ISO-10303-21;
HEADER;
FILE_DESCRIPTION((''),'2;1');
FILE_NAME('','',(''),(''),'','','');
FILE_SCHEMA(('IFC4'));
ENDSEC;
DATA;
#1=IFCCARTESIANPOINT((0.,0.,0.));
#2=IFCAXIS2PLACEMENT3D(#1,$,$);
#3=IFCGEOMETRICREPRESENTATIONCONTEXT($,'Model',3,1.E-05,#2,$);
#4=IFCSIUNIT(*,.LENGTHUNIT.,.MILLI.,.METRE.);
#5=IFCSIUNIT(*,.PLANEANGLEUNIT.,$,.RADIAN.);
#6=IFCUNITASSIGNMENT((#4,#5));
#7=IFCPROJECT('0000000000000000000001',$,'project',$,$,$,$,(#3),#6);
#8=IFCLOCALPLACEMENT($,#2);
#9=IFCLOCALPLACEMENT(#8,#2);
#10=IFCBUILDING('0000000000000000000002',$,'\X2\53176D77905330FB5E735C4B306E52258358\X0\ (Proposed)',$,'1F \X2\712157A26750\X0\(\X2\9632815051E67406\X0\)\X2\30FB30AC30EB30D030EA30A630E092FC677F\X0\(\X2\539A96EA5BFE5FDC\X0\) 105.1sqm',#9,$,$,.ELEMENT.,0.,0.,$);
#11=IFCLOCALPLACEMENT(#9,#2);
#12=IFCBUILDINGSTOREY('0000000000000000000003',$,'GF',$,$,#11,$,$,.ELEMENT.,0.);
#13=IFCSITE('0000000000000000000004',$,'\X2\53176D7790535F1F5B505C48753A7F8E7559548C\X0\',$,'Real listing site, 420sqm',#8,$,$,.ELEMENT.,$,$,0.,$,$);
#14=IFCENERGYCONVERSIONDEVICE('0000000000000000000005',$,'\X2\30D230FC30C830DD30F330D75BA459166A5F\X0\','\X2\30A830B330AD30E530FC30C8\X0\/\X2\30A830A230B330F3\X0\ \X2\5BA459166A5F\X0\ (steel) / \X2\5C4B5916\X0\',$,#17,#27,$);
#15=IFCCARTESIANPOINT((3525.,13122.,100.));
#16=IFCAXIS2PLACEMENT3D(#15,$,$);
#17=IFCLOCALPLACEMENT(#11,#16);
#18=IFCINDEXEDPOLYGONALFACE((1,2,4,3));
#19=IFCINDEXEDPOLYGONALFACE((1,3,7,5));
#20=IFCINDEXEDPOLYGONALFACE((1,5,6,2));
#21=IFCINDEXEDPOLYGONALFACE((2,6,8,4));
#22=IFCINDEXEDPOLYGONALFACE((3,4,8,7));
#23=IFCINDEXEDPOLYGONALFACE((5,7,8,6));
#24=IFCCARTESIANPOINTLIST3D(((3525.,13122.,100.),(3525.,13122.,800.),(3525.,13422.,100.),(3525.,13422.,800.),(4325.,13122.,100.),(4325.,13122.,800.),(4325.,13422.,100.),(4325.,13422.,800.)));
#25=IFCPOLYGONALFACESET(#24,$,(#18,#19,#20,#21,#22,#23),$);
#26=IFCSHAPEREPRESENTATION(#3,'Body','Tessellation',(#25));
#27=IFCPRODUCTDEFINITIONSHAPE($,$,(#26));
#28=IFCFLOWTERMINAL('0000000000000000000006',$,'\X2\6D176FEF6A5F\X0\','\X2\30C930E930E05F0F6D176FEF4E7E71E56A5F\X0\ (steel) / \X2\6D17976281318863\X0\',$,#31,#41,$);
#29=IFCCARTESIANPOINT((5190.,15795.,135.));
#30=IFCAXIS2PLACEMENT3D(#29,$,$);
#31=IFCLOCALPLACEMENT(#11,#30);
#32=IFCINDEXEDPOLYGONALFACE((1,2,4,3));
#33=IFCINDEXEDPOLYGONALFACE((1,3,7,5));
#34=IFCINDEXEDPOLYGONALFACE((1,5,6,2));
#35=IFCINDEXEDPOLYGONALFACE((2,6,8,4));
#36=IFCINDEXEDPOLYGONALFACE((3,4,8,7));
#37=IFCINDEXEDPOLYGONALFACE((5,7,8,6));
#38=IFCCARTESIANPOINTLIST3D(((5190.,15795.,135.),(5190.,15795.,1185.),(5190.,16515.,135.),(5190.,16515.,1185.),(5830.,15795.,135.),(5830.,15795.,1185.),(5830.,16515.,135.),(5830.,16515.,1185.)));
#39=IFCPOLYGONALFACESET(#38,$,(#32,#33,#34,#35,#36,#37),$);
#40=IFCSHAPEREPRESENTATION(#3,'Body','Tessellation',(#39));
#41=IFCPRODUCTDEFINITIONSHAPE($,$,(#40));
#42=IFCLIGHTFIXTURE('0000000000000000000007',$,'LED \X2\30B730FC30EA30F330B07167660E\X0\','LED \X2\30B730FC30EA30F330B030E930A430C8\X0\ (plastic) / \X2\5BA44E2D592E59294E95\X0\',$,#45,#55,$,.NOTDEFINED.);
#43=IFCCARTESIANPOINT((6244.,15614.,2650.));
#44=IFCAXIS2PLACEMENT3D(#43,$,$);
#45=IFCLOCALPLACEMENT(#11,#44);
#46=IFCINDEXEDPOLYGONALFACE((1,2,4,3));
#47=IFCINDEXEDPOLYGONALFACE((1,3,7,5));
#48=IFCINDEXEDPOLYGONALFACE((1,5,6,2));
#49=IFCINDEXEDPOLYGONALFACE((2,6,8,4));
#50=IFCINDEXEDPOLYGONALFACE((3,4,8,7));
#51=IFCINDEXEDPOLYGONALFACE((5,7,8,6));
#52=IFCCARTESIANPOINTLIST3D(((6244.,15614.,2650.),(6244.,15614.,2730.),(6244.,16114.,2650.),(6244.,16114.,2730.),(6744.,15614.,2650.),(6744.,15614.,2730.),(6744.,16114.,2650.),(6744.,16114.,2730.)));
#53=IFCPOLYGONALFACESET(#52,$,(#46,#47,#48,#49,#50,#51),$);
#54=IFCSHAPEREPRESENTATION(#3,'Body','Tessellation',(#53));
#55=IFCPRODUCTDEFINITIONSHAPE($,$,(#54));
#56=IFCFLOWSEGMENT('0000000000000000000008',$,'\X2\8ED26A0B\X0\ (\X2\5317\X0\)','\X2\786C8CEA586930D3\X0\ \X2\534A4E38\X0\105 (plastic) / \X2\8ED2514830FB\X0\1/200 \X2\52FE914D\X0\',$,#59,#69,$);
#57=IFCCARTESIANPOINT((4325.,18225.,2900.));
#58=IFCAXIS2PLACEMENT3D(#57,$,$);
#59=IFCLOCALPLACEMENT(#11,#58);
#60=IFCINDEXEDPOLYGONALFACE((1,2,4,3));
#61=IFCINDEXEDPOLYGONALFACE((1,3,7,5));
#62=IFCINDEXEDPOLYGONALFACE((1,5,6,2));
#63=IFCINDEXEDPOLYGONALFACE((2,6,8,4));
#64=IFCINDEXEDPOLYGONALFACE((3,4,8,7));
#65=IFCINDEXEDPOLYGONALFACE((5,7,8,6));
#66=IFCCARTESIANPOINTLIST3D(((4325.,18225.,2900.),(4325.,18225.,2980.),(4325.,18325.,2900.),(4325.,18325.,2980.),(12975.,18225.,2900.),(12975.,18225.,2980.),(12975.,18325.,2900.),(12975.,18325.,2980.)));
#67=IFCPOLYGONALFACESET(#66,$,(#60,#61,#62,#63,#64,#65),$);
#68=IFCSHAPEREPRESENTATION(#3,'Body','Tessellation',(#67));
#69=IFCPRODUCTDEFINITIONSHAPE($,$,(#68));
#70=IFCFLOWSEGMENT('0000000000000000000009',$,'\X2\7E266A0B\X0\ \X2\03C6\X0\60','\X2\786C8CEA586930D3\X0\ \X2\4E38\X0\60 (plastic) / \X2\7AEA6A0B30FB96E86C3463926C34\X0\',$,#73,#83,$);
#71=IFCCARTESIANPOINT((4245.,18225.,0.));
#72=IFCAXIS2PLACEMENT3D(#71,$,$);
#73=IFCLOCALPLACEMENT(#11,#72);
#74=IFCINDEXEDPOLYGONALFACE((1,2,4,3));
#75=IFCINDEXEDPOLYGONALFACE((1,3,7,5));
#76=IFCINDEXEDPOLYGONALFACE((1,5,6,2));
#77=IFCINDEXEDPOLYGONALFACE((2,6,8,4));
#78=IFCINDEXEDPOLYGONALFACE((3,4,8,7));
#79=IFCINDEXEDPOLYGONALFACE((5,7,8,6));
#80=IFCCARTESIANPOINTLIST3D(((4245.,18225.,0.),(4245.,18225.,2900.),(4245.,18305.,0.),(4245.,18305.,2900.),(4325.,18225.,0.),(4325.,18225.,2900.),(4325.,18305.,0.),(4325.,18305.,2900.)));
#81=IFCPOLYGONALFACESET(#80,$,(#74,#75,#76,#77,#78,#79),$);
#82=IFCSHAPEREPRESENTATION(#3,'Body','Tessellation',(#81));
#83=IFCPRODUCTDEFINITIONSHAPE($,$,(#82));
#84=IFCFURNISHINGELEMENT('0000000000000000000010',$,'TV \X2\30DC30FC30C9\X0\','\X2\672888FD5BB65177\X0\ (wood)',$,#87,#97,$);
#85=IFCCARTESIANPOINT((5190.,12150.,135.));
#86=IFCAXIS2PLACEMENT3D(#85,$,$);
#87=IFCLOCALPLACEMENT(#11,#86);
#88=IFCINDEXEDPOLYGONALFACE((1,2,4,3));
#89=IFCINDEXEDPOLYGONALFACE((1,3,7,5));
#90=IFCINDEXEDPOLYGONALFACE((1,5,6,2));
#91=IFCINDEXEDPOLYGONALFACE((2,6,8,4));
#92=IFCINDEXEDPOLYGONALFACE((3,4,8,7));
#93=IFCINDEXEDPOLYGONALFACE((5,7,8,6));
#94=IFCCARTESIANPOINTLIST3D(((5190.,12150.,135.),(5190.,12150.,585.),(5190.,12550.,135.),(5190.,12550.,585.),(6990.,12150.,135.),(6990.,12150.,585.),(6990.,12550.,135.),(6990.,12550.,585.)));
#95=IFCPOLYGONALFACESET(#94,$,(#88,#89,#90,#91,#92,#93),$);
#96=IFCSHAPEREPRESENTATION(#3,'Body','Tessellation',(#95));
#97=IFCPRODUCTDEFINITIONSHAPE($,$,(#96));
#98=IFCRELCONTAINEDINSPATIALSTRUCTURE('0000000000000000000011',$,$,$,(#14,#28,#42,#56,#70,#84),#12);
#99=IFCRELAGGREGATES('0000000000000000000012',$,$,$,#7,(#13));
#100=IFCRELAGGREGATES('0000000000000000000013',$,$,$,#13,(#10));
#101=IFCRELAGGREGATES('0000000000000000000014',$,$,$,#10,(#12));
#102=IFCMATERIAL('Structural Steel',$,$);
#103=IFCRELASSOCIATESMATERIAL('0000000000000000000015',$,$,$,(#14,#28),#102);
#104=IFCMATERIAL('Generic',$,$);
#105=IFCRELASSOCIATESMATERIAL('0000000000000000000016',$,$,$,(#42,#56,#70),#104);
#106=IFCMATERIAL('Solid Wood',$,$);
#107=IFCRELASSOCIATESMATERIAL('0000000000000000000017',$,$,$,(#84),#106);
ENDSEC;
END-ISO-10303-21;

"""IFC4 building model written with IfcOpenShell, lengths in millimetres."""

from ifc_helpers import new_model, si_unit, frame, frame_2d, origin, place, context, project, spatial, rectangle, extrude, material, element, save


model = new_model("IFC4")

# Units and contexts
model_context = context("Model", 3, precision=1e-05, world=origin())
ifc_project = project(units=[si_unit("LENGTHUNIT", "METRE", prefix="MILLI"), si_unit("PLANEANGLEUNIT", "RADIAN")], contexts=[model_context])

# Site, building, storey
site_placement = place(None, origin())
site = spatial("IfcSite", under=ifc_project, at=site_placement, Name="北海道弟子屈町美留和", ObjectType="Real listing site, 420sqm", CompositionType="ELEMENT", RefElevation=0.0)
building_placement = place(site_placement, origin())
building = spatial("IfcBuilding", under=site, at=building_placement, Name="北海道・平屋の別荘 (Proposed)", ObjectType="1F 無垢材(防腐処理)・ガルバリウム鋼板(厚雪対応) 105.1sqm", CompositionType="ELEMENT", ElevationOfRefHeight=0.0, ElevationOfTerrain=0.0)
storey_placement = place(building_placement, origin())
storey = spatial("IfcBuildingStorey", under=building, at=storey_placement, Name="GF", CompositionType="ELEMENT", Elevation=0.0)

# Shared definitions
ifc_material_1 = material(Name="Solid Wood")

# Shared definitions
ifc_material_2 = material(Name="Generic")

# Shared definitions
ifc_material_3 = material(Name="Structural Steel")

# Energy conversion device
energy_conversion_device_placement = place(storey_placement, frame((3525.0, 13122.0, 100.0)))
element("IfcEnergyConversionDevice", 1, at=energy_conversion_device_placement, inside=storey, material=ifc_material_3, Name="ヒートポンプ室外機", Description="エコキュート/エアコン 室外機 (steel) / 屋外", context=model_context, shape_type="SweptSolid", body=[
    extrude(rectangle(XDim=800.0, YDim=300.0, at=frame_2d((400.0, 150.0))), frame((3525.0, 13122.0, 100.0)), (0.0, 0.0, 1.0), 700.0),
])

# Flow terminal
flow_terminal_placement = place(storey_placement, frame((5190.0, 15795.0, 135.0)))
element("IfcFlowTerminal", 2, at=flow_terminal_placement, inside=storey, material=ifc_material_3, Name="洗濯機", Description="ドラム式洗濯乾燥機 (steel) / 洗面脱衣", context=model_context, shape_type="SweptSolid", body=[
    extrude(rectangle(XDim=640.0, YDim=720.0, at=frame_2d((320.0, 360.0))), frame((5190.0, 15795.0, 135.0)), (0.0, 0.0, 1.0), 1050.0),
])

# Light fixture
light_fixture_placement = place(storey_placement, frame((6244.0, 15614.0, 2650.0)))
element("IfcLightFixture", 3, at=light_fixture_placement, inside=storey, material=ifc_material_2, Name="LED シーリング照明", Description="LED シーリングライト (plastic) / 室中央天井", PredefinedType="NOTDEFINED", context=model_context, shape_type="SweptSolid", body=[
    extrude(rectangle(XDim=500.0, YDim=500.0, at=frame_2d((250.0, 250.0))), frame((6244.0, 15614.0, 2650.0)), (0.0, 0.0, 1.0), 80.0),
])

# Flow segments
flow_segment_1_placement = place(storey_placement, frame((4325.0, 18225.0, 2900.0)))
element("IfcFlowSegment", 4, at=flow_segment_1_placement, inside=storey, material=ifc_material_2, Name="軒樋 (北)", Description="硬質塩ビ 半丸105 (plastic) / 軒先・1/200 勾配", context=model_context, shape_type="SweptSolid", body=[
    extrude(rectangle(XDim=8650.0, YDim=100.0, at=frame_2d((4325.0, 50.0))), frame((4325.0, 18225.0, 2900.0)), (0.0, 0.0, 1.0), 80.0),
])
flow_segment_2_placement = place(storey_placement, frame((4245.0, 18225.0, 0.0)))
element("IfcFlowSegment", 5, at=flow_segment_2_placement, inside=storey, material=ifc_material_2, Name="縦樋 φ60", Description="硬質塩ビ 丸60 (plastic) / 竪樋・雨水排水", context=model_context, shape_type="SweptSolid", body=[
    extrude(rectangle(XDim=80.0, YDim=80.0, at=frame_2d((40.0, 40.0))), frame((4245.0, 18225.0, 0.0)), (0.0, 0.0, 1.0), 2900.0),
])

# Furnishing element
furnishing_placement = place(storey_placement, frame((5190.0, 12150.0, 135.0)))
element("IfcFurnishingElement", 6, at=furnishing_placement, inside=storey, material=ifc_material_1, Name="TV ボード", Description="木製家具 (wood)", context=model_context, shape_type="SweptSolid", body=[
    extrude(rectangle(XDim=1800.0, YDim=400.0, at=frame_2d((900.0, 200.0))), frame((5190.0, 12150.0, 135.0)), (0.0, 0.0, 1.0), 450.0),
])

save(model, "model.ifc")
